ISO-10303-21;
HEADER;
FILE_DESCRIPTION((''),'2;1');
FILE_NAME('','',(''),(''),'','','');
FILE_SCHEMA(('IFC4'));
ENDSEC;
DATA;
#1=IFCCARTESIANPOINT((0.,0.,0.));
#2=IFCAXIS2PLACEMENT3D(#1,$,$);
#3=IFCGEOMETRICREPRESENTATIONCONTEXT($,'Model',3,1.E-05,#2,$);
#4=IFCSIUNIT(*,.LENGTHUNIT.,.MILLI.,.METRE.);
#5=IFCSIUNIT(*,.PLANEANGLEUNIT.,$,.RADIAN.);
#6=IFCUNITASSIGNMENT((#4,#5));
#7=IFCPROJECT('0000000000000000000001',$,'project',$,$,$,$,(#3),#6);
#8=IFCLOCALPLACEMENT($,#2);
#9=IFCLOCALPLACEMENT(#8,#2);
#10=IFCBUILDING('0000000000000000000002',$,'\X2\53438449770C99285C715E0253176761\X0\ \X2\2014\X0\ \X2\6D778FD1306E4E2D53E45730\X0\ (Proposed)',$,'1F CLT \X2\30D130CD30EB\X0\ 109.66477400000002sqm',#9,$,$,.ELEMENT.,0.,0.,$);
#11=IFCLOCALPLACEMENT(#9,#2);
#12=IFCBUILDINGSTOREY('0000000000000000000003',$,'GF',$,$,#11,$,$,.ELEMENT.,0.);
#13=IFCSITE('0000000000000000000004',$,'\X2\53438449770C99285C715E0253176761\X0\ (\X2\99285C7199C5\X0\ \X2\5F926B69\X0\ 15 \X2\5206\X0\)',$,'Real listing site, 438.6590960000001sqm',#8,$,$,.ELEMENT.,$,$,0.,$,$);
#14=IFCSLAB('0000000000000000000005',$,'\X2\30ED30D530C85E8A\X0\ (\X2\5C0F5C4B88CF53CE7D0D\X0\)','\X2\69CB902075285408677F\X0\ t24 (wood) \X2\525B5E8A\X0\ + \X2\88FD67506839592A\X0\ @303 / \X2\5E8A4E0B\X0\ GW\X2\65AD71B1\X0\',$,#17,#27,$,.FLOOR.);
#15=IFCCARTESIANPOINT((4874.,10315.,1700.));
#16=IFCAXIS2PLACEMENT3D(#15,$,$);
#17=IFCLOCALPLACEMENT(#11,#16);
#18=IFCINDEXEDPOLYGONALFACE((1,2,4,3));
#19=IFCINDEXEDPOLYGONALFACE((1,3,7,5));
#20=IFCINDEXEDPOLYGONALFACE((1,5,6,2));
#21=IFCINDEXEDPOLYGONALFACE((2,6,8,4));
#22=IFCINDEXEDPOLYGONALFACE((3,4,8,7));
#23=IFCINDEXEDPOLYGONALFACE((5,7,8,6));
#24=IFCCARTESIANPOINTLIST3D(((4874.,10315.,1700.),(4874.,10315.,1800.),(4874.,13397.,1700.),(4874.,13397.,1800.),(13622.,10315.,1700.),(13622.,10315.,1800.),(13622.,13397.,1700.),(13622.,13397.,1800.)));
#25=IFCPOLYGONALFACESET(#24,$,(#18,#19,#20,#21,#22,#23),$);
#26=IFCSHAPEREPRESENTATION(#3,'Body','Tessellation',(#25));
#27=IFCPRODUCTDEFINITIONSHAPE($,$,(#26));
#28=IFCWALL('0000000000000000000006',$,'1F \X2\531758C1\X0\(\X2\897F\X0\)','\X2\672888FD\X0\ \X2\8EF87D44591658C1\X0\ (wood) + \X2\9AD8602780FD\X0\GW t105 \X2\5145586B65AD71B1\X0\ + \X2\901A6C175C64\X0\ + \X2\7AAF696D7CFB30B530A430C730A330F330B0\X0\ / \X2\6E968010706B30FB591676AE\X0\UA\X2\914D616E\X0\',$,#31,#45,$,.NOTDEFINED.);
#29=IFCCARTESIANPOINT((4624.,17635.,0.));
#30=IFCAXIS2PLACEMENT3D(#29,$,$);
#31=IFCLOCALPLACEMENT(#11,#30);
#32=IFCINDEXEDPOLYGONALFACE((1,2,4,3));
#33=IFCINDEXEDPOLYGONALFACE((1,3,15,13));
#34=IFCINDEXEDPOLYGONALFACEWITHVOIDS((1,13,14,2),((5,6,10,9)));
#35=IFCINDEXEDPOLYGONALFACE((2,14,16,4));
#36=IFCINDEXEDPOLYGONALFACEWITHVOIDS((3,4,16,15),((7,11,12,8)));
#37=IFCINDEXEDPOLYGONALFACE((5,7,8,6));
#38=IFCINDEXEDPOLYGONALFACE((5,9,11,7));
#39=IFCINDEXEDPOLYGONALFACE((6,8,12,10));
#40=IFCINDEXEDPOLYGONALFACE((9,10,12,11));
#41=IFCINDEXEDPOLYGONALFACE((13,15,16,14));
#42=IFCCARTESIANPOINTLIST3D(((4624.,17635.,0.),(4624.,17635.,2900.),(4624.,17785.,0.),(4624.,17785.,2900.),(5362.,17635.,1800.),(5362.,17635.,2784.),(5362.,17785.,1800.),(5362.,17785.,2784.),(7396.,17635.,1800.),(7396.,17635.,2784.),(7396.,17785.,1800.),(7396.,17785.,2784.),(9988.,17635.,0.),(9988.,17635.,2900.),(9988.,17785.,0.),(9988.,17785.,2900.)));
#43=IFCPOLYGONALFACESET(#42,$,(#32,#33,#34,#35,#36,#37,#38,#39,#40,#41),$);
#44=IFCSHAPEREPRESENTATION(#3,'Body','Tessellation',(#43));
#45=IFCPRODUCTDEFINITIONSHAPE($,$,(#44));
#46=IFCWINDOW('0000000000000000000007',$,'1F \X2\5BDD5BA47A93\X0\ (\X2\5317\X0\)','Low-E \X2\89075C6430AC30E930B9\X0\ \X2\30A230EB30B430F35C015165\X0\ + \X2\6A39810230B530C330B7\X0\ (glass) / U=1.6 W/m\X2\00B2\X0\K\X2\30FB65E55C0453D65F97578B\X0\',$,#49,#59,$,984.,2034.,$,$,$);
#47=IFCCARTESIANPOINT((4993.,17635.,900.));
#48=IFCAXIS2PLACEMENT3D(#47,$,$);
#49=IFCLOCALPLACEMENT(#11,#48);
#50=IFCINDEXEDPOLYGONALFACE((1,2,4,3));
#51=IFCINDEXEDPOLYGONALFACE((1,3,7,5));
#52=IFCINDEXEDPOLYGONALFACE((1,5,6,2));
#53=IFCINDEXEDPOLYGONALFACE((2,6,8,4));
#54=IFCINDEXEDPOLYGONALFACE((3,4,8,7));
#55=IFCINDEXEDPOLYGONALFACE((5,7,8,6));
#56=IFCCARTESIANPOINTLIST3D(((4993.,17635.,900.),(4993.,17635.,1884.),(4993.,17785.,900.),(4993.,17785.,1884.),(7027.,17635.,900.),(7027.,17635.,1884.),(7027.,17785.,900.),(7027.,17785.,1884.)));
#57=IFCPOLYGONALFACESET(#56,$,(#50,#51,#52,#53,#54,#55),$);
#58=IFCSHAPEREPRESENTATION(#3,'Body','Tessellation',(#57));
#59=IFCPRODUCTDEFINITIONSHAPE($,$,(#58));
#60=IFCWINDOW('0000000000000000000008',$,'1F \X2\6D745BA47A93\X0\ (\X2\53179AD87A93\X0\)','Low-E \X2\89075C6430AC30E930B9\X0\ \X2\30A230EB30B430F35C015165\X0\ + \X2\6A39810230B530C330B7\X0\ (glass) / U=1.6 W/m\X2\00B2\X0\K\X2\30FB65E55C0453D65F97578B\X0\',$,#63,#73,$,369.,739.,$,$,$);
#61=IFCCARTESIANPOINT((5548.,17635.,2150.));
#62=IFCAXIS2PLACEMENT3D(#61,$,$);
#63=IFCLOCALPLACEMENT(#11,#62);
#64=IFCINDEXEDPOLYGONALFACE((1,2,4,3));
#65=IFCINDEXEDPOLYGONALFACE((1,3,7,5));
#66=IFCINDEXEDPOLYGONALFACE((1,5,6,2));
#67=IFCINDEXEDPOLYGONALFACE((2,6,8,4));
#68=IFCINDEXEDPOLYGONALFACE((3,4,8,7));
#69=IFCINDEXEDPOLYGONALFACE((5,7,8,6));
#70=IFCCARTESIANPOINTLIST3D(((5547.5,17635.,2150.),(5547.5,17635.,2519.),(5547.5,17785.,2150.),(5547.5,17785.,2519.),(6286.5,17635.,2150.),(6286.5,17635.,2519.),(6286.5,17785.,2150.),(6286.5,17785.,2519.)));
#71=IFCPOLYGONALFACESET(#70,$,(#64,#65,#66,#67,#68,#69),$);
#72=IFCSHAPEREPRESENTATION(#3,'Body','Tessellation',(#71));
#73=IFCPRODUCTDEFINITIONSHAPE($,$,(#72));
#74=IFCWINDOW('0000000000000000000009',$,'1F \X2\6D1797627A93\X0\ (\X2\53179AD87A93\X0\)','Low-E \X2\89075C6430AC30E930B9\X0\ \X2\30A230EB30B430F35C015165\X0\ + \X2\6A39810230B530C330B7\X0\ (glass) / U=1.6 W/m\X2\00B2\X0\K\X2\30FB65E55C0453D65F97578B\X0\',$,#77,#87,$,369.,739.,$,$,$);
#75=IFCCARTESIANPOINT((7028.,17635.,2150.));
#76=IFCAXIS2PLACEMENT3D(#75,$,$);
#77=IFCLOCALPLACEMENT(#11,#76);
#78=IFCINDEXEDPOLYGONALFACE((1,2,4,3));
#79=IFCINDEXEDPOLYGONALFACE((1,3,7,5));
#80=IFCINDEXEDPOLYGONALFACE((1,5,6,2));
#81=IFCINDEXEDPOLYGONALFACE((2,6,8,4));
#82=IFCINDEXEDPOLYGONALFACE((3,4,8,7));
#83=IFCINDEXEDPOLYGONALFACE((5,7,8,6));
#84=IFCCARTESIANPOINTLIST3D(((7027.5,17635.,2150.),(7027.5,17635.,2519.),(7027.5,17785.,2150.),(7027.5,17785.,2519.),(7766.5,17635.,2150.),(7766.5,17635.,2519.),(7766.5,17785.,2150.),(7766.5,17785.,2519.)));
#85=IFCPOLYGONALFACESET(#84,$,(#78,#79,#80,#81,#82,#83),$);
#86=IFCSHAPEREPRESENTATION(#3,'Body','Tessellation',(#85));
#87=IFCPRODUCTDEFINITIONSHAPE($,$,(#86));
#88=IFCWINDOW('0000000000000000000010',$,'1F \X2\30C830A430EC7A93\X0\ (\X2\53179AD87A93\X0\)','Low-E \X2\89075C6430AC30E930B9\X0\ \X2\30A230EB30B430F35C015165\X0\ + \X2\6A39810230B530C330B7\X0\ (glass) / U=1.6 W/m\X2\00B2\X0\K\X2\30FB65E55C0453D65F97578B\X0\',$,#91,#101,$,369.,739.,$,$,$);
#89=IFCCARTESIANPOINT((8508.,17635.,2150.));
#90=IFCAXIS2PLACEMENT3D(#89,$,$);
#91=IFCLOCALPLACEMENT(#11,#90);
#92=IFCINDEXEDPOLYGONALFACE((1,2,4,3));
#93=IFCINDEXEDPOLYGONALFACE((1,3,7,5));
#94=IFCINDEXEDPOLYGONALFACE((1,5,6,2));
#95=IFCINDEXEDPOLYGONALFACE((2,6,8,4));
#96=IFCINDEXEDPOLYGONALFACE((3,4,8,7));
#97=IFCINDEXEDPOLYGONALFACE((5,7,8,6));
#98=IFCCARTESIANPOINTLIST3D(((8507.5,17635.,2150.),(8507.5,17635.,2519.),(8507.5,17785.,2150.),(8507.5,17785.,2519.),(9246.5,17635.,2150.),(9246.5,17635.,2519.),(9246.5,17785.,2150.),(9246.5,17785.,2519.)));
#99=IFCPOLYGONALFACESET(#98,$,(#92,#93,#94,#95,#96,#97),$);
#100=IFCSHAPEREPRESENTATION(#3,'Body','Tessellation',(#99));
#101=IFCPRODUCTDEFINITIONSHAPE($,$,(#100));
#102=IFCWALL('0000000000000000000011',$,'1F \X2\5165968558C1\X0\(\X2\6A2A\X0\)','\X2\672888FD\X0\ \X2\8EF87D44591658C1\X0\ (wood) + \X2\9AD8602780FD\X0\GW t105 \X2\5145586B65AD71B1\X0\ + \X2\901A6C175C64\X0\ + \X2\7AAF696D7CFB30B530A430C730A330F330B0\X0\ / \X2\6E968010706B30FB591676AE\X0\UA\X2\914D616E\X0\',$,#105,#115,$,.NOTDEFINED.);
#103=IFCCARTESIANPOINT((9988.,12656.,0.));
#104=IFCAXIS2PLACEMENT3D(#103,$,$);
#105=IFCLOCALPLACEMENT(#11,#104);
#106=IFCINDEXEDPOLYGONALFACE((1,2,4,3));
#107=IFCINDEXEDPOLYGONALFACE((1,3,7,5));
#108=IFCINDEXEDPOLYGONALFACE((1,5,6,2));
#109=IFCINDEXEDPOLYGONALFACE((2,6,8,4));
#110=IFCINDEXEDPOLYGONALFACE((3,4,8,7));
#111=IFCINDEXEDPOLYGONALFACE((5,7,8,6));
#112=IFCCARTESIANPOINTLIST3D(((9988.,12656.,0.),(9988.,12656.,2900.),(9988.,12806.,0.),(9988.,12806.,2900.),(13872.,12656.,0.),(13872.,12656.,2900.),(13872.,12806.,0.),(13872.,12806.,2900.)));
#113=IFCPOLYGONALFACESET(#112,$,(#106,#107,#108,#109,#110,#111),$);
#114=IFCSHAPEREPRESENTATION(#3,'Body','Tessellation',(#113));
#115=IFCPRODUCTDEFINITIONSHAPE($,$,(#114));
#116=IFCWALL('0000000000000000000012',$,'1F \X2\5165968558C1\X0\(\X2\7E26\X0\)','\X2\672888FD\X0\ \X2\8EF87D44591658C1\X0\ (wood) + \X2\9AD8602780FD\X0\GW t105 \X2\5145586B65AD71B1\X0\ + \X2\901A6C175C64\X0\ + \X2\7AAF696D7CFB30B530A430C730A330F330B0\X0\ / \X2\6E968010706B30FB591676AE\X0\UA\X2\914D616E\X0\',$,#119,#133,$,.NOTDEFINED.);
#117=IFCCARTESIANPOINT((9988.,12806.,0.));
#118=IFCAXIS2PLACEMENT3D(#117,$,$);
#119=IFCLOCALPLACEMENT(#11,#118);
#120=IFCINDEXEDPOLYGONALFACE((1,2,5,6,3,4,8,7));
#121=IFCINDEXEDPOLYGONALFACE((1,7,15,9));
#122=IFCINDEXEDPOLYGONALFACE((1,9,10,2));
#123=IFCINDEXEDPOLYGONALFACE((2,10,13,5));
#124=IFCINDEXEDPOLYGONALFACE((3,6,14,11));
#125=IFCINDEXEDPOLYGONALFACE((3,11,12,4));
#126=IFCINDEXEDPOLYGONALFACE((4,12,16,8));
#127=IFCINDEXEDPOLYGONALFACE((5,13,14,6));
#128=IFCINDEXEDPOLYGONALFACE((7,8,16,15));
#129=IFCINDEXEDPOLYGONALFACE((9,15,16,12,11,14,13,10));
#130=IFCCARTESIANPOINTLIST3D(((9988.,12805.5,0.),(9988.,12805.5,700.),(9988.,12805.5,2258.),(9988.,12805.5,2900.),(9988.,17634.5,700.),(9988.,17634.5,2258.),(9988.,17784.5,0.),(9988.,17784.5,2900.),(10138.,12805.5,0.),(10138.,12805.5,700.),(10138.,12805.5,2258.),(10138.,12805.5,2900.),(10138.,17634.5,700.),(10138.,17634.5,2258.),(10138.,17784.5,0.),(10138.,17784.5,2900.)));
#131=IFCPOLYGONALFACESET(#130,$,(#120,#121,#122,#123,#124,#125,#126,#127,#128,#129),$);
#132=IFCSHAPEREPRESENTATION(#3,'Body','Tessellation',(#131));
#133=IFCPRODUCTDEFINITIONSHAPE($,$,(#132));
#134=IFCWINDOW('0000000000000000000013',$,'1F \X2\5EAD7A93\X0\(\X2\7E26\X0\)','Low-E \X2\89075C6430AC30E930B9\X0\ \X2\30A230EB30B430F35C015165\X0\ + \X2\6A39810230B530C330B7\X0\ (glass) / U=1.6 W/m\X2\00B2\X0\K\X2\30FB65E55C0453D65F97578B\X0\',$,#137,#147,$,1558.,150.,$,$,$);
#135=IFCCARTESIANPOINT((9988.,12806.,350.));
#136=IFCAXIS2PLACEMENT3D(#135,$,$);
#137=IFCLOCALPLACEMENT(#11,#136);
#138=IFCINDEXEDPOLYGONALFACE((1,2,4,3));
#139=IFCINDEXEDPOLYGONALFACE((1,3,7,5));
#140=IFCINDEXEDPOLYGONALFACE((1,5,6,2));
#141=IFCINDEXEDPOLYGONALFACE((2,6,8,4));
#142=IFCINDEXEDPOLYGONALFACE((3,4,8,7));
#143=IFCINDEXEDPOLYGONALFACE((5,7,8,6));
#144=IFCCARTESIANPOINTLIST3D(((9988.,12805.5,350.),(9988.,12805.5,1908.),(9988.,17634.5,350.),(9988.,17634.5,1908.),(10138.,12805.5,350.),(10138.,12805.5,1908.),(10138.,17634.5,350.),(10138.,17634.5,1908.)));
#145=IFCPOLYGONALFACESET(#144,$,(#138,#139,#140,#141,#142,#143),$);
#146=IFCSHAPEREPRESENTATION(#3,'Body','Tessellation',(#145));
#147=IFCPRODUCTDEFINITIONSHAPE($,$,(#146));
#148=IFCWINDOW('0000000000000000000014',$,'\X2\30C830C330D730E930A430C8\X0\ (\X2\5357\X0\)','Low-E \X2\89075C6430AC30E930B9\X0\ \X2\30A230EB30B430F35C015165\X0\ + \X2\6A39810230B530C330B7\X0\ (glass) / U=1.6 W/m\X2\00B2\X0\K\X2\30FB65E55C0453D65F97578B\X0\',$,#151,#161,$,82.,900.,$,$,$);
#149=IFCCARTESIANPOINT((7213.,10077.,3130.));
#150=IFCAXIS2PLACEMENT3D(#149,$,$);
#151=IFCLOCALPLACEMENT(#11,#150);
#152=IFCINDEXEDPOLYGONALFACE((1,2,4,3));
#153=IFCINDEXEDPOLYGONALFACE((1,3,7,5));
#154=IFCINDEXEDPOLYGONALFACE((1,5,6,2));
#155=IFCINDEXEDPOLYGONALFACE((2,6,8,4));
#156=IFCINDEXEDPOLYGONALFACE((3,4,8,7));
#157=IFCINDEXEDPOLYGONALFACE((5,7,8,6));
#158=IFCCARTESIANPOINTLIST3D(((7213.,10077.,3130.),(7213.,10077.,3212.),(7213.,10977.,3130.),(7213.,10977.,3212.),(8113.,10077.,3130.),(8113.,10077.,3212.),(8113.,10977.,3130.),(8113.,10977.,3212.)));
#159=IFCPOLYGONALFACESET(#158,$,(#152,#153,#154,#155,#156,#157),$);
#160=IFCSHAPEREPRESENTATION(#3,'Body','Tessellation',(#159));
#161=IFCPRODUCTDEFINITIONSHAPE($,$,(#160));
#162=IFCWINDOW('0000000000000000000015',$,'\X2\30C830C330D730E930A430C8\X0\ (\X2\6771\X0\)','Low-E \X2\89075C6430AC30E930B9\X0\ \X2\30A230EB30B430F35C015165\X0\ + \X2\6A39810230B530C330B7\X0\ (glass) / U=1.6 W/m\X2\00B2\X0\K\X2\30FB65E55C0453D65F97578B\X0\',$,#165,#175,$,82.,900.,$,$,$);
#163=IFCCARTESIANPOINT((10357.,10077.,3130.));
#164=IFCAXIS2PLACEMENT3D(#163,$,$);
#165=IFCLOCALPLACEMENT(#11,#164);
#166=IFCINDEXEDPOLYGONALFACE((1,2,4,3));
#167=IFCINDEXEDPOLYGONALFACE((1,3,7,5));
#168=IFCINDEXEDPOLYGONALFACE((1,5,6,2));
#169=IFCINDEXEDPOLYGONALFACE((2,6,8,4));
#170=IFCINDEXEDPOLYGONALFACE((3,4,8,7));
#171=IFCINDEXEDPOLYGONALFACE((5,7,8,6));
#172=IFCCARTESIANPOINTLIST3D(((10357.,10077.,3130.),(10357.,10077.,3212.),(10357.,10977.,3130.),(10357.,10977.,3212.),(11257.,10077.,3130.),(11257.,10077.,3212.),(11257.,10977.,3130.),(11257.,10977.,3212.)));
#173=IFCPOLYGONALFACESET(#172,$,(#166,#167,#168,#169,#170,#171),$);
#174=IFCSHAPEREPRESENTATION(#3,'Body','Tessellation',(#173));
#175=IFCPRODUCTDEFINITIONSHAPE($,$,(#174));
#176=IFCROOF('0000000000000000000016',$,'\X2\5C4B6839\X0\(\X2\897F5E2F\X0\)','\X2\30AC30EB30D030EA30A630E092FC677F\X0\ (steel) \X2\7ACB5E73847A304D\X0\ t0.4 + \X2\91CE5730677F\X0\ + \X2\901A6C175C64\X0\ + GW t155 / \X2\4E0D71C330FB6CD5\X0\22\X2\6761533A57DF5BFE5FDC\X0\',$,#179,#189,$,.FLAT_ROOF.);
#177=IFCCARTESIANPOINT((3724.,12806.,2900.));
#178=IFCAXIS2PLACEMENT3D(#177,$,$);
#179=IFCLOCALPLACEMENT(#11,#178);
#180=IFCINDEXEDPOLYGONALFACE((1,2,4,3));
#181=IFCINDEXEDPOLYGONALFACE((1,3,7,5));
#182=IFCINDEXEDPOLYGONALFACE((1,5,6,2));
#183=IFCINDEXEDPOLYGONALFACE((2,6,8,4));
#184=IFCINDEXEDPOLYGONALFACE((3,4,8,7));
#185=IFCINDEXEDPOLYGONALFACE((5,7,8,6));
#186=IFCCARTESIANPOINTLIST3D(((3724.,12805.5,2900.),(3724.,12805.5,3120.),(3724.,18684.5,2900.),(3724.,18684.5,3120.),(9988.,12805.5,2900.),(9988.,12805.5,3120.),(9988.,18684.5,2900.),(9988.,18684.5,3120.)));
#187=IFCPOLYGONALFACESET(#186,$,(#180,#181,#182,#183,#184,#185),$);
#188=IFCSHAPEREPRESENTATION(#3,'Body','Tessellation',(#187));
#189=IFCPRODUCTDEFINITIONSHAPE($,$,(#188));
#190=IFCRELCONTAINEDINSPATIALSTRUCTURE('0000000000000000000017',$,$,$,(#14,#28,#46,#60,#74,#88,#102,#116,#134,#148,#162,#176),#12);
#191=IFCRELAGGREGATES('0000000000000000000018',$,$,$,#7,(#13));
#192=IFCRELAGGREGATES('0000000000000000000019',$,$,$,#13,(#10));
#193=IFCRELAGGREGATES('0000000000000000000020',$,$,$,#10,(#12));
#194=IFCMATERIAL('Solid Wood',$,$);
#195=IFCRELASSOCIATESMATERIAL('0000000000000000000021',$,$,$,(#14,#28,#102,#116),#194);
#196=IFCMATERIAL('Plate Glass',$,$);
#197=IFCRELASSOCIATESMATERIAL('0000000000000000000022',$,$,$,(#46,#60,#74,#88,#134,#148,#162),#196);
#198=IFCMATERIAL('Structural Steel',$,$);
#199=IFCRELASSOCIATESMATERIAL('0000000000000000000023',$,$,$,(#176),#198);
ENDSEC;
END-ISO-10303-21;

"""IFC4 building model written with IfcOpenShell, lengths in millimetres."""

from ifc_helpers import new_model, si_unit, frame, frame_2d, origin, place, context, project, spatial, rectangle, extrude, material, element, fill, save


model = new_model("IFC4")

# Units and contexts
model_context = context("Model", 3, precision=1e-05, world=origin())
ifc_project = project(units=[si_unit("LENGTHUNIT", "METRE", prefix="MILLI"), si_unit("PLANEANGLEUNIT", "RADIAN")], contexts=[model_context])

# Site, building, storey
site_placement = place(None, origin())
site = spatial("IfcSite", under=ifc_project, at=site_placement, Name="千葉県館山市北条 (館山駅 徒歩 15 分)", ObjectType="Real listing site, 438.6590960000001sqm", CompositionType="ELEMENT", RefElevation=0.0)
building_placement = place(site_placement, origin())
building = spatial("IfcBuilding", under=site, at=building_placement, Name="千葉県館山市北条 — 海近の中古地 (Proposed)", ObjectType="1F CLT パネル 109.66477400000002sqm", CompositionType="ELEMENT", ElevationOfRefHeight=0.0, ElevationOfTerrain=0.0)
storey_placement = place(building_placement, origin())
storey = spatial("IfcBuildingStorey", under=building, at=storey_placement, Name="GF", CompositionType="ELEMENT", Elevation=0.0)

# Slab
ifc_material_1 = material(Name="Solid Wood")
slab_1_placement = place(storey_placement, frame((4874.0, 10315.0, 1700.0)))
element("IfcSlab", 1, at=slab_1_placement, inside=storey, material=ifc_material_1, Name="ロフト床 (小屋裏収納)", Description="構造用合板 t24 (wood) 剛床 + 製材根太 @303 / 床下 GW断熱", PredefinedType="FLOOR", context=model_context, shape_type="SweptSolid", body=[
    extrude(rectangle(XDim=8748.0, YDim=3082.0, at=frame_2d((4374.0, 1541.0))), frame((4874.0, 10315.0, 1700.0)), (0.0, 0.0, 1.0), 100.0),
])

# Wall, openings, windows
wall_1_placement = place(storey_placement, frame((4624.0, 17635.0, 0.0)))
wall_1 = element("IfcWall", 2, at=wall_1_placement, inside=storey, material=ifc_material_1, Name="1F 北壁(西)", Description="木製 軸組外壁 (wood) + 高性能GW t105 充填断熱 + 通気層 + 窯業系サイディング / 準耐火・外皮UA配慮", PredefinedType="NOTDEFINED", context=model_context, shape_type="SweptSolid", body=[
    extrude(rectangle(XDim=5364.0, YDim=150.0, at=frame_2d((2682.0, 75.0))), frame((4624.0, 17635.0, 0.0)), (0.0, 0.0, 1.0), 2900.0),
])
opening_1_placement = place(storey_placement, frame((4993.0, 17635.0, 900.0)))
opening_1 = element("IfcOpeningElement", 3, at=opening_1_placement, cuts=wall_1, PredefinedType="NOTDEFINED", context=model_context, shape_type="SweptSolid", body=[
    extrude(rectangle(XDim=2034.0, YDim=150.0, at=frame_2d((1017.0, 75.0))), frame((4993.0, 17635.0, 900.0)), (0.0, 0.0, 1.0), 984.0),
])
opening_2_placement = place(storey_placement, frame((5548.0, 17635.0, 2150.0)))
opening_2 = element("IfcOpeningElement", 4, at=opening_2_placement, cuts=wall_1, PredefinedType="NOTDEFINED", context=model_context, shape_type="SweptSolid", body=[
    extrude(rectangle(XDim=739.0, YDim=150.0, at=frame_2d((369.0, 75.0))), frame((5548.0, 17635.0, 2150.0)), (0.0, 0.0, 1.0), 369.0),
])
opening_3_placement = place(storey_placement, frame((7028.0, 17635.0, 2150.0)))
opening_3 = element("IfcOpeningElement", 5, at=opening_3_placement, cuts=wall_1, PredefinedType="NOTDEFINED", context=model_context, shape_type="SweptSolid", body=[
    extrude(rectangle(XDim=739.0, YDim=150.0, at=frame_2d((369.0, 75.0))), frame((7028.0, 17635.0, 2150.0)), (0.0, 0.0, 1.0), 369.0),
])
opening_4_placement = place(storey_placement, frame((8508.0, 17635.0, 2150.0)))
opening_4 = element("IfcOpeningElement", 6, at=opening_4_placement, cuts=wall_1, PredefinedType="NOTDEFINED", context=model_context, shape_type="SweptSolid", body=[
    extrude(rectangle(XDim=739.0, YDim=150.0, at=frame_2d((369.0, 75.0))), frame((8508.0, 17635.0, 2150.0)), (0.0, 0.0, 1.0), 369.0),
])
ifc_material_2 = material(Name="Plate Glass")
window_1_placement = place(storey_placement, frame((4993.0, 17635.0, 900.0)))
window_1 = element("IfcWindow", 7, at=window_1_placement, inside=storey, material=ifc_material_2, Name="1F 寝室窓 (北)", Description="Low-E 複層ガラス アルゴン封入 + 樹脂サッシ (glass) / U=1.6 W/m²K・日射取得型", OverallHeight=984.0, OverallWidth=2034.0, context=model_context, shape_type="SweptSolid", body=[
    extrude(rectangle(XDim=2034.0, YDim=150.0, at=frame_2d((1017.0, 75.0))), frame((4993.0, 17635.0, 900.0)), (0.0, 0.0, 1.0), 984.0),
])
fill(opening_1, window_1)
window_2_placement = place(storey_placement, frame((5548.0, 17635.0, 2150.0)))
window_2 = element("IfcWindow", 8, at=window_2_placement, inside=storey, material=ifc_material_2, Name="1F 浴室窓 (北高窓)", Description="Low-E 複層ガラス アルゴン封入 + 樹脂サッシ (glass) / U=1.6 W/m²K・日射取得型", OverallHeight=369.0, OverallWidth=739.0, context=model_context, shape_type="SweptSolid", body=[
    extrude(rectangle(XDim=739.0, YDim=150.0, at=frame_2d((369.0, 75.0))), frame((5548.0, 17635.0, 2150.0)), (0.0, 0.0, 1.0), 369.0),
])
fill(opening_2, window_2)
window_3_placement = place(storey_placement, frame((7028.0, 17635.0, 2150.0)))
window_3 = element("IfcWindow", 9, at=window_3_placement, inside=storey, material=ifc_material_2, Name="1F 洗面窓 (北高窓)", Description="Low-E 複層ガラス アルゴン封入 + 樹脂サッシ (glass) / U=1.6 W/m²K・日射取得型", OverallHeight=369.0, OverallWidth=739.0, context=model_context, shape_type="SweptSolid", body=[
    extrude(rectangle(XDim=739.0, YDim=150.0, at=frame_2d((369.0, 75.0))), frame((7028.0, 17635.0, 2150.0)), (0.0, 0.0, 1.0), 369.0),
])
fill(opening_3, window_3)
window_4_placement = place(storey_placement, frame((8508.0, 17635.0, 2150.0)))
window_4 = element("IfcWindow", 10, at=window_4_placement, inside=storey, material=ifc_material_2, Name="1F トイレ窓 (北高窓)", Description="Low-E 複層ガラス アルゴン封入 + 樹脂サッシ (glass) / U=1.6 W/m²K・日射取得型", OverallHeight=369.0, OverallWidth=739.0, context=model_context, shape_type="SweptSolid", body=[
    extrude(rectangle(XDim=739.0, YDim=150.0, at=frame_2d((369.0, 75.0))), frame((8508.0, 17635.0, 2150.0)), (0.0, 0.0, 1.0), 369.0),
])
fill(opening_4, window_4)

# Wall
wall_2_placement = place(storey_placement, frame((9988.0, 12656.0, 0.0)))
element("IfcWall", 11, at=wall_2_placement, inside=storey, material=ifc_material_1, Name="1F 入隅壁(横)", Description="木製 軸組外壁 (wood) + 高性能GW t105 充填断熱 + 通気層 + 窯業系サイディング / 準耐火・外皮UA配慮", PredefinedType="NOTDEFINED", context=model_context, shape_type="SweptSolid", body=[
    extrude(rectangle(XDim=3884.0, YDim=150.0, at=frame_2d((1942.0, 75.0))), frame((9988.0, 12656.0, 0.0)), (0.0, 0.0, 1.0), 2900.0),
])

# Wall, opening, window
wall_3_placement = place(storey_placement, frame((9988.0, 12806.0, 0.0)))
wall_3 = element("IfcWall", 12, at=wall_3_placement, inside=storey, material=ifc_material_1, Name="1F 入隅壁(縦)", Description="木製 軸組外壁 (wood) + 高性能GW t105 充填断熱 + 通気層 + 窯業系サイディング / 準耐火・外皮UA配慮", PredefinedType="NOTDEFINED", context=model_context, shape_type="SweptSolid", body=[
    extrude(rectangle(XDim=150.0, YDim=4979.0, at=frame_2d((75.0, 2489.0))), frame((9988.0, 12806.0, 0.0)), (0.0, 0.0, 1.0), 2900.0),
])
opening_5_placement = place(storey_placement, frame((9988.0, 12806.0, 350.0)))
opening_5 = element("IfcOpeningElement", 13, at=opening_5_placement, cuts=wall_3, PredefinedType="NOTDEFINED", context=model_context, shape_type="SweptSolid", body=[
    extrude(rectangle(XDim=150.0, YDim=4829.0, at=frame_2d((75.0, 2414.0))), frame((9988.0, 12806.0, 350.0)), (0.0, 0.0, 1.0), 1558.0),
])
window_5_placement = place(storey_placement, frame((9988.0, 12806.0, 350.0)))
window_5 = element("IfcWindow", 14, at=window_5_placement, inside=storey, material=ifc_material_2, Name="1F 庭窓(縦)", Description="Low-E 複層ガラス アルゴン封入 + 樹脂サッシ (glass) / U=1.6 W/m²K・日射取得型", OverallHeight=1558.0, OverallWidth=150.0, context=model_context, shape_type="SweptSolid", body=[
    extrude(rectangle(XDim=150.0, YDim=4829.0, at=frame_2d((75.0, 2414.0))), frame((9988.0, 12806.0, 350.0)), (0.0, 0.0, 1.0), 1558.0),
])
fill(opening_5, window_5)

# Windows
window_6_placement = place(storey_placement, frame((7213.0, 10077.0, 3130.0)))
element("IfcWindow", 15, at=window_6_placement, inside=storey, material=ifc_material_2, Name="トップライト (南)", Description="Low-E 複層ガラス アルゴン封入 + 樹脂サッシ (glass) / U=1.6 W/m²K・日射取得型", OverallHeight=82.0, OverallWidth=900.0, context=model_context, shape_type="SweptSolid", body=[
    extrude(rectangle(XDim=900.0, YDim=900.0, at=frame_2d((450.0, 450.0))), frame((7213.0, 10077.0, 3130.0)), (0.0, 0.0, 1.0), 82.0),
])
window_7_placement = place(storey_placement, frame((10357.0, 10077.0, 3130.0)))
element("IfcWindow", 16, at=window_7_placement, inside=storey, material=ifc_material_2, Name="トップライト (東)", Description="Low-E 複層ガラス アルゴン封入 + 樹脂サッシ (glass) / U=1.6 W/m²K・日射取得型", OverallHeight=82.0, OverallWidth=900.0, context=model_context, shape_type="SweptSolid", body=[
    extrude(rectangle(XDim=900.0, YDim=900.0, at=frame_2d((450.0, 450.0))), frame((10357.0, 10077.0, 3130.0)), (0.0, 0.0, 1.0), 82.0),
])

# Roof
ifc_material_3 = material(Name="Structural Steel")
roof_placement = place(storey_placement, frame((3724.0, 12806.0, 2900.0)))
element("IfcRoof", 17, at=roof_placement, inside=storey, material=ifc_material_3, Name="屋根(西帯)", Description="ガルバリウム鋼板 (steel) 立平葺き t0.4 + 野地板 + 通気層 + GW t155 / 不燃・法22条区域対応", PredefinedType="FLAT_ROOF", context=model_context, shape_type="SweptSolid", body=[
    extrude(rectangle(XDim=6264.0, YDim=5879.0, at=frame_2d((3132.0, 2939.0))), frame((3724.0, 12806.0, 2900.0)), (0.0, 0.0, 1.0), 220.0),
])

save(model, "model.ifc")
